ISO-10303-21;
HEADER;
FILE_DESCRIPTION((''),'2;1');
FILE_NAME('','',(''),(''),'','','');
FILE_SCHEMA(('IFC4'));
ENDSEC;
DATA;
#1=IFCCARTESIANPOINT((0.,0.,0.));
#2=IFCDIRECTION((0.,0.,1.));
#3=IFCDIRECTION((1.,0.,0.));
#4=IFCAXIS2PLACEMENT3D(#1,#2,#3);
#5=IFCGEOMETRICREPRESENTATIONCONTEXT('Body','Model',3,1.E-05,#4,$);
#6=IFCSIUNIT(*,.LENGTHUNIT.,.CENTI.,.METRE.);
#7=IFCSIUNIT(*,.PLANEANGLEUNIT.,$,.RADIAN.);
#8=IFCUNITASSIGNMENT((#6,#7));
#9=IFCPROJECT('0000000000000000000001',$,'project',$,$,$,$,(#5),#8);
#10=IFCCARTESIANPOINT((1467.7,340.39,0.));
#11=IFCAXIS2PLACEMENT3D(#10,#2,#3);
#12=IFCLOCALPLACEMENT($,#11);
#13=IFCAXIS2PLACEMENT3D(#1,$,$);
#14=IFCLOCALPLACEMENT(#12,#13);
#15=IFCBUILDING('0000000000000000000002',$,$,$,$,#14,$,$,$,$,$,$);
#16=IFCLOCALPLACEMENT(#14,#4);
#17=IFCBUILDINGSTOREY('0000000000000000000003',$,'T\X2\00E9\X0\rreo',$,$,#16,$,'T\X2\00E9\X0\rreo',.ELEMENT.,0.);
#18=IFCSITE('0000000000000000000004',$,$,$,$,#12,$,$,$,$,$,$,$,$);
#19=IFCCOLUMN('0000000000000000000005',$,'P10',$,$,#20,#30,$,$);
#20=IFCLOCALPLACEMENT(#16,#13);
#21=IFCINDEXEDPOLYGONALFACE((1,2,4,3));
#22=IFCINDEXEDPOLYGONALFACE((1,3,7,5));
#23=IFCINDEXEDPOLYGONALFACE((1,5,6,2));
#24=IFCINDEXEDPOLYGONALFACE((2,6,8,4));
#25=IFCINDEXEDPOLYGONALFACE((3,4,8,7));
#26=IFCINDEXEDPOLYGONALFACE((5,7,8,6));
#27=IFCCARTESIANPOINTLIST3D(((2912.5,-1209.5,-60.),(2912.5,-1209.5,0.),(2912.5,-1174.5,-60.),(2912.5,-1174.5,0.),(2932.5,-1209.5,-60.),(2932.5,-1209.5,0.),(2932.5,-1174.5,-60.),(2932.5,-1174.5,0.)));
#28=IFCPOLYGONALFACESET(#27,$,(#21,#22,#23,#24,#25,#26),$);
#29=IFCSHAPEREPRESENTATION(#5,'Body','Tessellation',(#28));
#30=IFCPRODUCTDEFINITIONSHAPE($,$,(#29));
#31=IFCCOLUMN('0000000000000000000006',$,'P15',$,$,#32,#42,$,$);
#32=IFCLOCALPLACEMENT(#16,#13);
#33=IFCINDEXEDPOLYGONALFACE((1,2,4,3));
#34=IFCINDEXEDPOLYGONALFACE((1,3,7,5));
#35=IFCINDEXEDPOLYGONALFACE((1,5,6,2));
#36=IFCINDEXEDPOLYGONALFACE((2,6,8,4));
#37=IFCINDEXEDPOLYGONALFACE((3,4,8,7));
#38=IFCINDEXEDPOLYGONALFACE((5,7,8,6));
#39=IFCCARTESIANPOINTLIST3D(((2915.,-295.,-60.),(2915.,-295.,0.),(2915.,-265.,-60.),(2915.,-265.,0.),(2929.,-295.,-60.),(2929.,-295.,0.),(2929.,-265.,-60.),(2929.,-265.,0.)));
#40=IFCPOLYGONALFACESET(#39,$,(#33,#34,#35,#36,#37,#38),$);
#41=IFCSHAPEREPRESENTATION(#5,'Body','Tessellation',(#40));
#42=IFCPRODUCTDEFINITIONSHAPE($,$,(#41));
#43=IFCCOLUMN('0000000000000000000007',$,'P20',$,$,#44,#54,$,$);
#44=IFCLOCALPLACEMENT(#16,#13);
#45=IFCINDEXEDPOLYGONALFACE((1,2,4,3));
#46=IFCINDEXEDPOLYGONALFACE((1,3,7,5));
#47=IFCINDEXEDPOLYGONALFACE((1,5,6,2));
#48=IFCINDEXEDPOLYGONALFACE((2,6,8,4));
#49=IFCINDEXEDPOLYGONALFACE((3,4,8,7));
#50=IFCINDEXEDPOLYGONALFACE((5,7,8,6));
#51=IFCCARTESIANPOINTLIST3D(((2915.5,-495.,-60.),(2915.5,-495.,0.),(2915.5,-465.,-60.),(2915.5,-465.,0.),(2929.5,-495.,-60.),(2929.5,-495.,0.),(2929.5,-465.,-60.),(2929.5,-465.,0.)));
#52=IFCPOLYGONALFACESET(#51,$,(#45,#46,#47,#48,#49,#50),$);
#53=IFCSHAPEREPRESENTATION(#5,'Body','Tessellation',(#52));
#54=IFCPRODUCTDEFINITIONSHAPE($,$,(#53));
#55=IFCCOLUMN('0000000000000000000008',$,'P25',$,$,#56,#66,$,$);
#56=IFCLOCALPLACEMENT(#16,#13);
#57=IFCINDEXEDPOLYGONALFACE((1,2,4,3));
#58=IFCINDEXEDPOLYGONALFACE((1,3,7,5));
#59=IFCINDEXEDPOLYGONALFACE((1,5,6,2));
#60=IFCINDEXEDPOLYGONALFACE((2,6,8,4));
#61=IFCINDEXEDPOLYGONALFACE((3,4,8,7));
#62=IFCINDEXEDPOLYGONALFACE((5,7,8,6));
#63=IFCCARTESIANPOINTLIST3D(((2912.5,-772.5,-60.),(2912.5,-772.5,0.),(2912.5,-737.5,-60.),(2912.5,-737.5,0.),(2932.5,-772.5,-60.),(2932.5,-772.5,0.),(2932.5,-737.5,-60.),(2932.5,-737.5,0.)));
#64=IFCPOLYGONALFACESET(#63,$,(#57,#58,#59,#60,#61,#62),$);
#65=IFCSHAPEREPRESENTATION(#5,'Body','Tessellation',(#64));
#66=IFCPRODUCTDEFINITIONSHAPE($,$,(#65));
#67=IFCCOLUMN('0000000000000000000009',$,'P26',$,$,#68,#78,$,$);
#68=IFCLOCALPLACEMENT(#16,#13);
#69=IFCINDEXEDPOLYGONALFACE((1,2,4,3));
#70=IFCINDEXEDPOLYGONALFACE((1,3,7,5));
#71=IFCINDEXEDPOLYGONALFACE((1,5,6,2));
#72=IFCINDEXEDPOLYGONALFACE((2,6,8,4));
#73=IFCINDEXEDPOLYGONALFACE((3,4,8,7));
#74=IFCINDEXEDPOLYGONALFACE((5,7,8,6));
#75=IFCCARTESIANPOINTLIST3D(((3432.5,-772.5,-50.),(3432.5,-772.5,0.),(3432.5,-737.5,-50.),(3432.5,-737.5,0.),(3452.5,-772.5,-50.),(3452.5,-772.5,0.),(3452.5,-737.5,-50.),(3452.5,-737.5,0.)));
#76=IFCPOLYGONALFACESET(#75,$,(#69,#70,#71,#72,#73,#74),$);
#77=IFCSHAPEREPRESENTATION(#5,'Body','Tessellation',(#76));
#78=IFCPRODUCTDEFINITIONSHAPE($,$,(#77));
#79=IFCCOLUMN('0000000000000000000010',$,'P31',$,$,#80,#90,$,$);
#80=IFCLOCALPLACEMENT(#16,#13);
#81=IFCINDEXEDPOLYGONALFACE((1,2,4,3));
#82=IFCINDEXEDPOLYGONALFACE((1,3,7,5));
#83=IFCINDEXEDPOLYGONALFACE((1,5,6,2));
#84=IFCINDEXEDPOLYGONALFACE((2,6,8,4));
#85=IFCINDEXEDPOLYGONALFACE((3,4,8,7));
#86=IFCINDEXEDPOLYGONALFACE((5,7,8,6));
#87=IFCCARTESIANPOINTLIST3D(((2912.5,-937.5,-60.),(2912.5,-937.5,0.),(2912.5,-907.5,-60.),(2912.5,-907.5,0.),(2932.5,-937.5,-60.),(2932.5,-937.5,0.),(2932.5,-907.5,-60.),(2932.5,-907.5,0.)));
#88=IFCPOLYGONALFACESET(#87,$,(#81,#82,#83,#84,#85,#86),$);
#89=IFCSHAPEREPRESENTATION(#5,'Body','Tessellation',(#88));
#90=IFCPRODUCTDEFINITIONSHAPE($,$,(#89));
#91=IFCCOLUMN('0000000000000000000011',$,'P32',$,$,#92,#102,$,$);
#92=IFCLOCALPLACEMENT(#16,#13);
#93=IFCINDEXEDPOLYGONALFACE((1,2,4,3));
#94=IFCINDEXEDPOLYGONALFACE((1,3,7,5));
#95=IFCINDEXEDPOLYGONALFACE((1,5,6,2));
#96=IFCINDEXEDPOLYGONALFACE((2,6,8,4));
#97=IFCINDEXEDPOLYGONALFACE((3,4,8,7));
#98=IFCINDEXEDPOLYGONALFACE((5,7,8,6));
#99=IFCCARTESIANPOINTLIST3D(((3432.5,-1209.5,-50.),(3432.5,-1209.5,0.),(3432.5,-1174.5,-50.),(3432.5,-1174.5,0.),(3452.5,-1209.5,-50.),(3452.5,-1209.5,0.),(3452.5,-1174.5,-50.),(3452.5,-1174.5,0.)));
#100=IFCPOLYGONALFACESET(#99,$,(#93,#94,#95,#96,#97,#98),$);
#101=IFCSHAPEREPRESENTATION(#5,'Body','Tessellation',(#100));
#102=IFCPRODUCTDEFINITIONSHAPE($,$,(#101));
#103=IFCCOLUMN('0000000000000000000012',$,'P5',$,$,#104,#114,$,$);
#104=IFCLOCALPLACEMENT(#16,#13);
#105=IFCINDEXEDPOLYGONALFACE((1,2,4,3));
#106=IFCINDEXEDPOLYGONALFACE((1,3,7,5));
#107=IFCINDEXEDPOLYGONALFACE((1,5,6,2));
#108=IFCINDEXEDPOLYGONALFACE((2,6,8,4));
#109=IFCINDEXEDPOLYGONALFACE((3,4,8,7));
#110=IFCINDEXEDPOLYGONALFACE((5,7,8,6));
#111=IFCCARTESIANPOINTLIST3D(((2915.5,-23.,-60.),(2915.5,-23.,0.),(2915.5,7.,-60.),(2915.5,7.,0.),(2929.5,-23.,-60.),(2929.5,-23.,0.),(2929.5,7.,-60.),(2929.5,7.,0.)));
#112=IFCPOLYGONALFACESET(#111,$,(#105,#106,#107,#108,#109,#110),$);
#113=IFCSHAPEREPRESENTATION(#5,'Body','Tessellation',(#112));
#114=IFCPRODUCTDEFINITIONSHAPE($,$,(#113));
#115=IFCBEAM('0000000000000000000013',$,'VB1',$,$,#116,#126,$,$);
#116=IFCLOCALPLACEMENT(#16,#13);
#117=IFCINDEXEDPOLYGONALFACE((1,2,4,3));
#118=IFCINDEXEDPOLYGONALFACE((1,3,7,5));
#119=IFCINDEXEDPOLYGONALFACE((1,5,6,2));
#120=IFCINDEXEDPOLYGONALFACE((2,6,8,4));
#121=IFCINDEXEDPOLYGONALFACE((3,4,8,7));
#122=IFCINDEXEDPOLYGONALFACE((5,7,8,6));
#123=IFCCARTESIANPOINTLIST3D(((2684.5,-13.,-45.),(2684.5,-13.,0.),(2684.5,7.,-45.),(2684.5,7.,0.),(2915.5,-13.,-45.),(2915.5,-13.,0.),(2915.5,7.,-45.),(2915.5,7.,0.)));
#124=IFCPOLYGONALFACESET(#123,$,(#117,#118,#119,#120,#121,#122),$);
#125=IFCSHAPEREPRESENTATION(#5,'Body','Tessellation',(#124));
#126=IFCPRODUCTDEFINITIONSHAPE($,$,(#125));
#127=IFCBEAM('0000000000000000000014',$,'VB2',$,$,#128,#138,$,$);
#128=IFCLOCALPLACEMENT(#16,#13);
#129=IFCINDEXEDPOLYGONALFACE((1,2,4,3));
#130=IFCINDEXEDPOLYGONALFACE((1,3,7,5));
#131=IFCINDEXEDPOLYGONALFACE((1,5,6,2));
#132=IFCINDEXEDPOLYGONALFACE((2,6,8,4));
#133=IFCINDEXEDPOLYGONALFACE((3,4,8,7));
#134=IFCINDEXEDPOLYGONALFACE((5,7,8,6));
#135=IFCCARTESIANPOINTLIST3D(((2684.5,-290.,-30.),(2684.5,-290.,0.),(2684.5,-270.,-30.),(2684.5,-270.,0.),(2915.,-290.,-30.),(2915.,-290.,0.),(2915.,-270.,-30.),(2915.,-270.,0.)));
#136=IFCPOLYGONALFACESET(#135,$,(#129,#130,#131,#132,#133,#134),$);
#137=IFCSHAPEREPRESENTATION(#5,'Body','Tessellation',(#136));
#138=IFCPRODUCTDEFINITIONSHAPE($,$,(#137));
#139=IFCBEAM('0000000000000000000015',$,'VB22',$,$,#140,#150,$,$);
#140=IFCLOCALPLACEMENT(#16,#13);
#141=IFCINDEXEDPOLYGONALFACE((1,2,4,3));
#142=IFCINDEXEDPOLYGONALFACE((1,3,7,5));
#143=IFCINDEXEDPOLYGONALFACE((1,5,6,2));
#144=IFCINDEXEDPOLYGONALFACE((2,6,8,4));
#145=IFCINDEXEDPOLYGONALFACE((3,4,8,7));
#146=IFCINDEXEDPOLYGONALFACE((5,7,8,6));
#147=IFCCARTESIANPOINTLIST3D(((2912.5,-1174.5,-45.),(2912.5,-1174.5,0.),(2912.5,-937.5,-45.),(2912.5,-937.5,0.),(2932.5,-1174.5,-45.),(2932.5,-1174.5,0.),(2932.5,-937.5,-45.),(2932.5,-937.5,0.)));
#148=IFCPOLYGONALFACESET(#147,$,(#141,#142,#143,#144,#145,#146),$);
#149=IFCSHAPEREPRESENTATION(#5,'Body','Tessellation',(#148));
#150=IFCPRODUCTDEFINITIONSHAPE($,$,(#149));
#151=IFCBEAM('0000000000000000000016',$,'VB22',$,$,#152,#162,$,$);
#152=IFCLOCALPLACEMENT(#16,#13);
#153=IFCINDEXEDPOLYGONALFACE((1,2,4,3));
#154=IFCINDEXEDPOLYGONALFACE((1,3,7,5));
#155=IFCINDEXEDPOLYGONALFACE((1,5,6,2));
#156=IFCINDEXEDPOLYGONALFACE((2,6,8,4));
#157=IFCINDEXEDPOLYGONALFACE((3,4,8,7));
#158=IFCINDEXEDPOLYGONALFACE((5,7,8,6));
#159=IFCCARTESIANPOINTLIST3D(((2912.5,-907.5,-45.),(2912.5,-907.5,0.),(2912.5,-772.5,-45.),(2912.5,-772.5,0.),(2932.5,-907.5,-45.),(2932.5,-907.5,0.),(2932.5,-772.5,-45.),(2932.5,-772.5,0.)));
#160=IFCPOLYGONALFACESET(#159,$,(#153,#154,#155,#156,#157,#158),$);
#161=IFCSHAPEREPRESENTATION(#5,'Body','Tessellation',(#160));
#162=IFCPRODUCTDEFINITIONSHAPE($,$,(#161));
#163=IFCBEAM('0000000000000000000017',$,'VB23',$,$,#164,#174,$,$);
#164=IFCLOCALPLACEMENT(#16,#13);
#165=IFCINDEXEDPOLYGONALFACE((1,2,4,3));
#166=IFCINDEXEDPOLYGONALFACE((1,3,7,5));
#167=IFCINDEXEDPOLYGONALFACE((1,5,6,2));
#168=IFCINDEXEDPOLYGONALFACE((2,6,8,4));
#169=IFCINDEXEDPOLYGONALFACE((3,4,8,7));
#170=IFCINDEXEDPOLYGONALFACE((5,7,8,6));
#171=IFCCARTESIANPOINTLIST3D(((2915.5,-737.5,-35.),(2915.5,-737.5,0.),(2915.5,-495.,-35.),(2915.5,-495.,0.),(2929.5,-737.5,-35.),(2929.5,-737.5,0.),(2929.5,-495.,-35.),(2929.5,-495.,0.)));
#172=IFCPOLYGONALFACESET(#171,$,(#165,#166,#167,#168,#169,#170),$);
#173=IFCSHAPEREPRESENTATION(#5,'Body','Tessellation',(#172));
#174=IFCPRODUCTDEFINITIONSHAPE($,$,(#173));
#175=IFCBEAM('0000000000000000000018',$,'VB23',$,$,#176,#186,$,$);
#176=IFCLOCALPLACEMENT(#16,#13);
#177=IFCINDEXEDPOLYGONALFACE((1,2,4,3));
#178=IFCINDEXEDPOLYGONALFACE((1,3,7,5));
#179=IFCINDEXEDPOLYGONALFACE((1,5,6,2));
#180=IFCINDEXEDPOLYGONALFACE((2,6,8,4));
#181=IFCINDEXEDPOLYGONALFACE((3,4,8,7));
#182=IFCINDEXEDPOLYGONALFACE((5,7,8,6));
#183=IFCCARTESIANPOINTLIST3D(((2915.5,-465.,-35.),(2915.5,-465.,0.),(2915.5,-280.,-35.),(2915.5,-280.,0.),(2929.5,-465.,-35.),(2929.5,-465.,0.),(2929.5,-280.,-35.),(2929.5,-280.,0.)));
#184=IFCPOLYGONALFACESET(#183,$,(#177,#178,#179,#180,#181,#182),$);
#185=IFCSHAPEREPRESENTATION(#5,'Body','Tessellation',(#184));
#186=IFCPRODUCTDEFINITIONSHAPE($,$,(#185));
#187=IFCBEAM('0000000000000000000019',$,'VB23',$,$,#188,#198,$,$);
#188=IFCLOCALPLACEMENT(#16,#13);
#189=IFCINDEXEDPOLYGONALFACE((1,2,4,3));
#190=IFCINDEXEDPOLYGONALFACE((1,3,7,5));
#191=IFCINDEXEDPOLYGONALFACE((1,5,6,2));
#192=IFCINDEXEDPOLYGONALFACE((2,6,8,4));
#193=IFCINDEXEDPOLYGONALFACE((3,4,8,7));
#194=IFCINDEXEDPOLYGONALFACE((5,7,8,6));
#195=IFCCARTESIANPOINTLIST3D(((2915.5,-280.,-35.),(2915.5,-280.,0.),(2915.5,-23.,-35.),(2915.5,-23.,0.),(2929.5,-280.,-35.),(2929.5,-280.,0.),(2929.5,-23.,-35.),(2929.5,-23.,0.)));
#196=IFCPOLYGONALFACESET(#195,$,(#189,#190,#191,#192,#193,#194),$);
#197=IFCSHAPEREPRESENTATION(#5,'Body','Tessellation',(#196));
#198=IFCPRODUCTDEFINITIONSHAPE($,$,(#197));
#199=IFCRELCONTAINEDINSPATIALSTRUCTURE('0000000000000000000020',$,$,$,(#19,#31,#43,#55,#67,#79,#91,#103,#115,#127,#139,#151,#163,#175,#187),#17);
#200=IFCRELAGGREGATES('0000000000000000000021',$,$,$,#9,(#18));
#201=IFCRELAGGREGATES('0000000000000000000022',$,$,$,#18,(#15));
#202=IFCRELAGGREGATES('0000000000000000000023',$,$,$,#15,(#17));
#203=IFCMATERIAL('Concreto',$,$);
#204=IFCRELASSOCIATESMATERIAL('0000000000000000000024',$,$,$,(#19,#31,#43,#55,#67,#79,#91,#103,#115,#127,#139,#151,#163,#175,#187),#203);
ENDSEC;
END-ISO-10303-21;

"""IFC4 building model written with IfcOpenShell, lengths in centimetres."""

from ifc_helpers import new_model, si_unit, frame, origin, origin_with_axes, origin_2d_with_axis, place, context, project, spatial, rectangle, extrude, material, element, save


model = new_model("IFC4")

# Units and contexts
model_context = context("Model", 3, precision=1e-05, world=origin_with_axes(), identifier="Body")
ifc_project = project(units=[si_unit("LENGTHUNIT", "METRE", prefix="CENTI"), si_unit("PLANEANGLEUNIT", "RADIAN")], contexts=[model_context])

# Site, building, storey
site_placement = place(None, frame((1467.7, 340.39, 0.0), z_axis=(0.0, 0.0, 1.0), x_axis=(1.0, 0.0, 0.0)))
site = spatial("IfcSite", under=ifc_project, at=site_placement)
building_placement = place(site_placement, origin())
building = spatial("IfcBuilding", under=site, at=building_placement)
storey_placement = place(building_placement, origin_with_axes())
storey = spatial("IfcBuildingStorey", under=building, at=storey_placement, Name="Térreo", LongName="Térreo", CompositionType="ELEMENT", Elevation=0.0)

# Columns
ifc_material = material(Name="Concreto")
column_1_placement = place(storey_placement, frame((2922.5, -1192.0, 0.0), z_axis=(0.0, 0.0, 1.0), x_axis=(1.0, 0.0, 0.0)))
element("IfcColumn", 1, at=column_1_placement, inside=storey, material=ifc_material, Name="P10", context=model_context, shape_type="SolidModel", body=[
    extrude(rectangle(XDim=20.0, YDim=35.0, at=origin_2d_with_axis()), frame((0.0, 0.0, -60.0), z_axis=(0.0, 0.0, 1.0), x_axis=(1.0, 0.0, 0.0)), (0.0, 0.0, 1.0), 60.0),
])
for number, where, z_axis, x_axis, name in (
    (2, (2922.0, -280.0, 0.0), (0.0, 0.0, 1.0), (1.0, 0.0, 0.0), "P15"),
    (3, (2922.5, -480.0, 0.0), (0.0, 0.0, 1.0), (1.0, 0.0, 0.0), "P20"),
):
    element("IfcColumn", number, at=place(storey_placement, frame(where, z_axis=z_axis, x_axis=x_axis)), inside=storey, material=ifc_material, Name=name, context=model_context, shape_type="SolidModel", body=[
        extrude(rectangle(XDim=14.0, YDim=30.0, at=origin_2d_with_axis()), frame((0.0, 0.0, -60.0), z_axis=(0.0, 0.0, 1.0), x_axis=(1.0, 0.0, 0.0)), (0.0, 0.0, 1.0), 60.0),
    ])
column_2_placement = place(storey_placement, frame((2922.5, -755.0, 0.0), z_axis=(0.0, 0.0, 1.0), x_axis=(1.0, 0.0, 0.0)))
element("IfcColumn", 4, at=column_2_placement, inside=storey, material=ifc_material, Name="P25", context=model_context, shape_type="SolidModel", body=[
    extrude(rectangle(XDim=20.0, YDim=35.0, at=origin_2d_with_axis()), frame((0.0, 0.0, -60.0), z_axis=(0.0, 0.0, 1.0), x_axis=(-1.0, 0.0, 0.0)), (0.0, 0.0, 1.0), 60.0),
])
column_3_placement = place(storey_placement, frame((3442.5, -755.0, 0.0), z_axis=(0.0, 0.0, 1.0), x_axis=(1.0, 0.0, 0.0)))
element("IfcColumn", 5, at=column_3_placement, inside=storey, material=ifc_material, Name="P26", context=model_context, shape_type="SolidModel", body=[
    extrude(rectangle(XDim=20.0, YDim=35.0, at=origin_2d_with_axis()), frame((0.0, 0.0, -50.0), z_axis=(0.0, 0.0, 1.0), x_axis=(1.0, 0.0, 0.0)), (0.0, 0.0, 1.0), 50.0),
])
column_4_placement = place(storey_placement, frame((2922.5, -922.5, 0.0), z_axis=(0.0, 0.0, 1.0), x_axis=(1.0, 0.0, 0.0)))
element("IfcColumn", 6, at=column_4_placement, inside=storey, material=ifc_material, Name="P31", context=model_context, shape_type="SolidModel", body=[
    extrude(rectangle(XDim=20.0, YDim=30.0, at=origin_2d_with_axis()), frame((0.0, 0.0, -60.0), z_axis=(0.0, 0.0, 1.0), x_axis=(1.0, 0.0, 0.0)), (0.0, 0.0, 1.0), 60.0),
])
column_5_placement = place(storey_placement, frame((3442.5, -1192.0, 0.0), z_axis=(0.0, 0.0, 1.0), x_axis=(1.0, 0.0, 0.0)))
element("IfcColumn", 7, at=column_5_placement, inside=storey, material=ifc_material, Name="P32", context=model_context, shape_type="SolidModel", body=[
    extrude(rectangle(XDim=20.0, YDim=35.0, at=origin_2d_with_axis()), frame((0.0, 0.0, -50.0), z_axis=(0.0, 0.0, 1.0), x_axis=(1.0, 0.0, 0.0)), (0.0, 0.0, 1.0), 50.0),
])
column_6_placement = place(storey_placement, frame((2922.5, -8.0, 0.0), z_axis=(0.0, 0.0, 1.0), x_axis=(1.0, 0.0, 0.0)))
element("IfcColumn", 8, at=column_6_placement, inside=storey, material=ifc_material, Name="P5", context=model_context, shape_type="SolidModel", body=[
    extrude(rectangle(XDim=14.0, YDim=30.0, at=origin_2d_with_axis()), frame((0.0, 0.0, -60.0), z_axis=(0.0, 0.0, 1.0), x_axis=(1.0, 0.0, 0.0)), (0.0, 0.0, 1.0), 60.0),
])

# Beams
beam_1_placement = place(storey_placement, frame((2800.0, -3.0, 0.0), z_axis=(0.0, 0.0, 1.0), x_axis=(1.0, 0.0, 0.0)))
element("IfcBeam", 9, at=beam_1_placement, inside=storey, material=ifc_material, Name="VB1", context=model_context, shape_type="SolidModel", body=[
    extrude(rectangle(XDim=20.0, YDim=45.0, at=origin_2d_with_axis()), frame((-115.5, 0.0, -22.5), z_axis=(1.0, 0.0, 0.0), x_axis=(0.0, 1.0, 0.0)), (0.0, 0.0, 1.0), 231.0),
])
beam_2_placement = place(storey_placement, frame((2799.75, -280.0, 0.0), z_axis=(0.0, 0.0, 1.0), x_axis=(1.0, 0.0, 0.0)))
element("IfcBeam", 10, at=beam_2_placement, inside=storey, material=ifc_material, Name="VB2", context=model_context, shape_type="SolidModel", body=[
    extrude(rectangle(XDim=20.0, YDim=30.0, at=origin_2d_with_axis()), frame((-115.25, 0.0, -15.0), z_axis=(1.0, 0.0, 0.0), x_axis=(0.0, 1.0, 0.0)), (0.0, 0.0, 1.0), 230.5),
])
beam_3_placement = place(storey_placement, frame((2922.5, -1056.0, 0.0), z_axis=(0.0, 0.0, 1.0), x_axis=(1.0, 0.0, 0.0)))
element("IfcBeam", 11, at=beam_3_placement, inside=storey, material=ifc_material, Name="VB22", context=model_context, shape_type="SolidModel", body=[
    extrude(rectangle(XDim=20.0, YDim=45.0, at=origin_2d_with_axis()), frame((0.0, -118.5, -22.5), z_axis=(0.0, 1.0, 0.0), x_axis=(1.0, 0.0, 0.0)), (0.0, 0.0, 1.0), 237.0),
])
beam_4_placement = place(storey_placement, frame((2922.5, -840.0, 0.0), z_axis=(0.0, 0.0, 1.0), x_axis=(1.0, 0.0, 0.0)))
element("IfcBeam", 12, at=beam_4_placement, inside=storey, material=ifc_material, Name="VB22", context=model_context, shape_type="SolidModel", body=[
    extrude(rectangle(XDim=20.0, YDim=45.0, at=origin_2d_with_axis()), frame((0.0, -67.5, -22.5), z_axis=(0.0, 1.0, 0.0), x_axis=(1.0, 0.0, 0.0)), (0.0, 0.0, 1.0), 135.0),
])
beam_5_placement = place(storey_placement, frame((2922.5, -616.25, 0.0), z_axis=(0.0, 0.0, 1.0), x_axis=(1.0, 0.0, 0.0)))
element("IfcBeam", 13, at=beam_5_placement, inside=storey, material=ifc_material, Name="VB23", context=model_context, shape_type="SolidModel", body=[
    extrude(rectangle(XDim=14.0, YDim=35.0, at=origin_2d_with_axis()), frame((0.0, -121.25, -17.5), z_axis=(0.0, 1.0, 0.0), x_axis=(1.0, 0.0, 0.0)), (0.0, 0.0, 1.0), 242.5),
])
beam_6_placement = place(storey_placement, frame((2922.5, -372.5, 0.0), z_axis=(0.0, 0.0, 1.0), x_axis=(1.0, 0.0, 0.0)))
element("IfcBeam", 14, at=beam_6_placement, inside=storey, material=ifc_material, Name="VB23", context=model_context, shape_type="SolidModel", body=[
    extrude(rectangle(XDim=14.0, YDim=35.0, at=origin_2d_with_axis()), frame((0.0, -92.5, -17.5), z_axis=(0.0, 1.0, 0.0), x_axis=(1.0, 0.0, 0.0)), (0.0, 0.0, 1.0), 185.0),
])
beam_7_placement = place(storey_placement, frame((2922.5, -151.5, 0.0), z_axis=(0.0, 0.0, 1.0), x_axis=(1.0, 0.0, 0.0)))
element("IfcBeam", 15, at=beam_7_placement, inside=storey, material=ifc_material, Name="VB23", context=model_context, shape_type="SolidModel", body=[
    extrude(rectangle(XDim=14.0, YDim=35.0, at=origin_2d_with_axis()), frame((0.0, -128.5, -17.5), z_axis=(0.0, 1.0, 0.0), x_axis=(1.0, 0.0, 0.0)), (0.0, 0.0, 1.0), 257.0),
])

save(model, "model.ifc")
